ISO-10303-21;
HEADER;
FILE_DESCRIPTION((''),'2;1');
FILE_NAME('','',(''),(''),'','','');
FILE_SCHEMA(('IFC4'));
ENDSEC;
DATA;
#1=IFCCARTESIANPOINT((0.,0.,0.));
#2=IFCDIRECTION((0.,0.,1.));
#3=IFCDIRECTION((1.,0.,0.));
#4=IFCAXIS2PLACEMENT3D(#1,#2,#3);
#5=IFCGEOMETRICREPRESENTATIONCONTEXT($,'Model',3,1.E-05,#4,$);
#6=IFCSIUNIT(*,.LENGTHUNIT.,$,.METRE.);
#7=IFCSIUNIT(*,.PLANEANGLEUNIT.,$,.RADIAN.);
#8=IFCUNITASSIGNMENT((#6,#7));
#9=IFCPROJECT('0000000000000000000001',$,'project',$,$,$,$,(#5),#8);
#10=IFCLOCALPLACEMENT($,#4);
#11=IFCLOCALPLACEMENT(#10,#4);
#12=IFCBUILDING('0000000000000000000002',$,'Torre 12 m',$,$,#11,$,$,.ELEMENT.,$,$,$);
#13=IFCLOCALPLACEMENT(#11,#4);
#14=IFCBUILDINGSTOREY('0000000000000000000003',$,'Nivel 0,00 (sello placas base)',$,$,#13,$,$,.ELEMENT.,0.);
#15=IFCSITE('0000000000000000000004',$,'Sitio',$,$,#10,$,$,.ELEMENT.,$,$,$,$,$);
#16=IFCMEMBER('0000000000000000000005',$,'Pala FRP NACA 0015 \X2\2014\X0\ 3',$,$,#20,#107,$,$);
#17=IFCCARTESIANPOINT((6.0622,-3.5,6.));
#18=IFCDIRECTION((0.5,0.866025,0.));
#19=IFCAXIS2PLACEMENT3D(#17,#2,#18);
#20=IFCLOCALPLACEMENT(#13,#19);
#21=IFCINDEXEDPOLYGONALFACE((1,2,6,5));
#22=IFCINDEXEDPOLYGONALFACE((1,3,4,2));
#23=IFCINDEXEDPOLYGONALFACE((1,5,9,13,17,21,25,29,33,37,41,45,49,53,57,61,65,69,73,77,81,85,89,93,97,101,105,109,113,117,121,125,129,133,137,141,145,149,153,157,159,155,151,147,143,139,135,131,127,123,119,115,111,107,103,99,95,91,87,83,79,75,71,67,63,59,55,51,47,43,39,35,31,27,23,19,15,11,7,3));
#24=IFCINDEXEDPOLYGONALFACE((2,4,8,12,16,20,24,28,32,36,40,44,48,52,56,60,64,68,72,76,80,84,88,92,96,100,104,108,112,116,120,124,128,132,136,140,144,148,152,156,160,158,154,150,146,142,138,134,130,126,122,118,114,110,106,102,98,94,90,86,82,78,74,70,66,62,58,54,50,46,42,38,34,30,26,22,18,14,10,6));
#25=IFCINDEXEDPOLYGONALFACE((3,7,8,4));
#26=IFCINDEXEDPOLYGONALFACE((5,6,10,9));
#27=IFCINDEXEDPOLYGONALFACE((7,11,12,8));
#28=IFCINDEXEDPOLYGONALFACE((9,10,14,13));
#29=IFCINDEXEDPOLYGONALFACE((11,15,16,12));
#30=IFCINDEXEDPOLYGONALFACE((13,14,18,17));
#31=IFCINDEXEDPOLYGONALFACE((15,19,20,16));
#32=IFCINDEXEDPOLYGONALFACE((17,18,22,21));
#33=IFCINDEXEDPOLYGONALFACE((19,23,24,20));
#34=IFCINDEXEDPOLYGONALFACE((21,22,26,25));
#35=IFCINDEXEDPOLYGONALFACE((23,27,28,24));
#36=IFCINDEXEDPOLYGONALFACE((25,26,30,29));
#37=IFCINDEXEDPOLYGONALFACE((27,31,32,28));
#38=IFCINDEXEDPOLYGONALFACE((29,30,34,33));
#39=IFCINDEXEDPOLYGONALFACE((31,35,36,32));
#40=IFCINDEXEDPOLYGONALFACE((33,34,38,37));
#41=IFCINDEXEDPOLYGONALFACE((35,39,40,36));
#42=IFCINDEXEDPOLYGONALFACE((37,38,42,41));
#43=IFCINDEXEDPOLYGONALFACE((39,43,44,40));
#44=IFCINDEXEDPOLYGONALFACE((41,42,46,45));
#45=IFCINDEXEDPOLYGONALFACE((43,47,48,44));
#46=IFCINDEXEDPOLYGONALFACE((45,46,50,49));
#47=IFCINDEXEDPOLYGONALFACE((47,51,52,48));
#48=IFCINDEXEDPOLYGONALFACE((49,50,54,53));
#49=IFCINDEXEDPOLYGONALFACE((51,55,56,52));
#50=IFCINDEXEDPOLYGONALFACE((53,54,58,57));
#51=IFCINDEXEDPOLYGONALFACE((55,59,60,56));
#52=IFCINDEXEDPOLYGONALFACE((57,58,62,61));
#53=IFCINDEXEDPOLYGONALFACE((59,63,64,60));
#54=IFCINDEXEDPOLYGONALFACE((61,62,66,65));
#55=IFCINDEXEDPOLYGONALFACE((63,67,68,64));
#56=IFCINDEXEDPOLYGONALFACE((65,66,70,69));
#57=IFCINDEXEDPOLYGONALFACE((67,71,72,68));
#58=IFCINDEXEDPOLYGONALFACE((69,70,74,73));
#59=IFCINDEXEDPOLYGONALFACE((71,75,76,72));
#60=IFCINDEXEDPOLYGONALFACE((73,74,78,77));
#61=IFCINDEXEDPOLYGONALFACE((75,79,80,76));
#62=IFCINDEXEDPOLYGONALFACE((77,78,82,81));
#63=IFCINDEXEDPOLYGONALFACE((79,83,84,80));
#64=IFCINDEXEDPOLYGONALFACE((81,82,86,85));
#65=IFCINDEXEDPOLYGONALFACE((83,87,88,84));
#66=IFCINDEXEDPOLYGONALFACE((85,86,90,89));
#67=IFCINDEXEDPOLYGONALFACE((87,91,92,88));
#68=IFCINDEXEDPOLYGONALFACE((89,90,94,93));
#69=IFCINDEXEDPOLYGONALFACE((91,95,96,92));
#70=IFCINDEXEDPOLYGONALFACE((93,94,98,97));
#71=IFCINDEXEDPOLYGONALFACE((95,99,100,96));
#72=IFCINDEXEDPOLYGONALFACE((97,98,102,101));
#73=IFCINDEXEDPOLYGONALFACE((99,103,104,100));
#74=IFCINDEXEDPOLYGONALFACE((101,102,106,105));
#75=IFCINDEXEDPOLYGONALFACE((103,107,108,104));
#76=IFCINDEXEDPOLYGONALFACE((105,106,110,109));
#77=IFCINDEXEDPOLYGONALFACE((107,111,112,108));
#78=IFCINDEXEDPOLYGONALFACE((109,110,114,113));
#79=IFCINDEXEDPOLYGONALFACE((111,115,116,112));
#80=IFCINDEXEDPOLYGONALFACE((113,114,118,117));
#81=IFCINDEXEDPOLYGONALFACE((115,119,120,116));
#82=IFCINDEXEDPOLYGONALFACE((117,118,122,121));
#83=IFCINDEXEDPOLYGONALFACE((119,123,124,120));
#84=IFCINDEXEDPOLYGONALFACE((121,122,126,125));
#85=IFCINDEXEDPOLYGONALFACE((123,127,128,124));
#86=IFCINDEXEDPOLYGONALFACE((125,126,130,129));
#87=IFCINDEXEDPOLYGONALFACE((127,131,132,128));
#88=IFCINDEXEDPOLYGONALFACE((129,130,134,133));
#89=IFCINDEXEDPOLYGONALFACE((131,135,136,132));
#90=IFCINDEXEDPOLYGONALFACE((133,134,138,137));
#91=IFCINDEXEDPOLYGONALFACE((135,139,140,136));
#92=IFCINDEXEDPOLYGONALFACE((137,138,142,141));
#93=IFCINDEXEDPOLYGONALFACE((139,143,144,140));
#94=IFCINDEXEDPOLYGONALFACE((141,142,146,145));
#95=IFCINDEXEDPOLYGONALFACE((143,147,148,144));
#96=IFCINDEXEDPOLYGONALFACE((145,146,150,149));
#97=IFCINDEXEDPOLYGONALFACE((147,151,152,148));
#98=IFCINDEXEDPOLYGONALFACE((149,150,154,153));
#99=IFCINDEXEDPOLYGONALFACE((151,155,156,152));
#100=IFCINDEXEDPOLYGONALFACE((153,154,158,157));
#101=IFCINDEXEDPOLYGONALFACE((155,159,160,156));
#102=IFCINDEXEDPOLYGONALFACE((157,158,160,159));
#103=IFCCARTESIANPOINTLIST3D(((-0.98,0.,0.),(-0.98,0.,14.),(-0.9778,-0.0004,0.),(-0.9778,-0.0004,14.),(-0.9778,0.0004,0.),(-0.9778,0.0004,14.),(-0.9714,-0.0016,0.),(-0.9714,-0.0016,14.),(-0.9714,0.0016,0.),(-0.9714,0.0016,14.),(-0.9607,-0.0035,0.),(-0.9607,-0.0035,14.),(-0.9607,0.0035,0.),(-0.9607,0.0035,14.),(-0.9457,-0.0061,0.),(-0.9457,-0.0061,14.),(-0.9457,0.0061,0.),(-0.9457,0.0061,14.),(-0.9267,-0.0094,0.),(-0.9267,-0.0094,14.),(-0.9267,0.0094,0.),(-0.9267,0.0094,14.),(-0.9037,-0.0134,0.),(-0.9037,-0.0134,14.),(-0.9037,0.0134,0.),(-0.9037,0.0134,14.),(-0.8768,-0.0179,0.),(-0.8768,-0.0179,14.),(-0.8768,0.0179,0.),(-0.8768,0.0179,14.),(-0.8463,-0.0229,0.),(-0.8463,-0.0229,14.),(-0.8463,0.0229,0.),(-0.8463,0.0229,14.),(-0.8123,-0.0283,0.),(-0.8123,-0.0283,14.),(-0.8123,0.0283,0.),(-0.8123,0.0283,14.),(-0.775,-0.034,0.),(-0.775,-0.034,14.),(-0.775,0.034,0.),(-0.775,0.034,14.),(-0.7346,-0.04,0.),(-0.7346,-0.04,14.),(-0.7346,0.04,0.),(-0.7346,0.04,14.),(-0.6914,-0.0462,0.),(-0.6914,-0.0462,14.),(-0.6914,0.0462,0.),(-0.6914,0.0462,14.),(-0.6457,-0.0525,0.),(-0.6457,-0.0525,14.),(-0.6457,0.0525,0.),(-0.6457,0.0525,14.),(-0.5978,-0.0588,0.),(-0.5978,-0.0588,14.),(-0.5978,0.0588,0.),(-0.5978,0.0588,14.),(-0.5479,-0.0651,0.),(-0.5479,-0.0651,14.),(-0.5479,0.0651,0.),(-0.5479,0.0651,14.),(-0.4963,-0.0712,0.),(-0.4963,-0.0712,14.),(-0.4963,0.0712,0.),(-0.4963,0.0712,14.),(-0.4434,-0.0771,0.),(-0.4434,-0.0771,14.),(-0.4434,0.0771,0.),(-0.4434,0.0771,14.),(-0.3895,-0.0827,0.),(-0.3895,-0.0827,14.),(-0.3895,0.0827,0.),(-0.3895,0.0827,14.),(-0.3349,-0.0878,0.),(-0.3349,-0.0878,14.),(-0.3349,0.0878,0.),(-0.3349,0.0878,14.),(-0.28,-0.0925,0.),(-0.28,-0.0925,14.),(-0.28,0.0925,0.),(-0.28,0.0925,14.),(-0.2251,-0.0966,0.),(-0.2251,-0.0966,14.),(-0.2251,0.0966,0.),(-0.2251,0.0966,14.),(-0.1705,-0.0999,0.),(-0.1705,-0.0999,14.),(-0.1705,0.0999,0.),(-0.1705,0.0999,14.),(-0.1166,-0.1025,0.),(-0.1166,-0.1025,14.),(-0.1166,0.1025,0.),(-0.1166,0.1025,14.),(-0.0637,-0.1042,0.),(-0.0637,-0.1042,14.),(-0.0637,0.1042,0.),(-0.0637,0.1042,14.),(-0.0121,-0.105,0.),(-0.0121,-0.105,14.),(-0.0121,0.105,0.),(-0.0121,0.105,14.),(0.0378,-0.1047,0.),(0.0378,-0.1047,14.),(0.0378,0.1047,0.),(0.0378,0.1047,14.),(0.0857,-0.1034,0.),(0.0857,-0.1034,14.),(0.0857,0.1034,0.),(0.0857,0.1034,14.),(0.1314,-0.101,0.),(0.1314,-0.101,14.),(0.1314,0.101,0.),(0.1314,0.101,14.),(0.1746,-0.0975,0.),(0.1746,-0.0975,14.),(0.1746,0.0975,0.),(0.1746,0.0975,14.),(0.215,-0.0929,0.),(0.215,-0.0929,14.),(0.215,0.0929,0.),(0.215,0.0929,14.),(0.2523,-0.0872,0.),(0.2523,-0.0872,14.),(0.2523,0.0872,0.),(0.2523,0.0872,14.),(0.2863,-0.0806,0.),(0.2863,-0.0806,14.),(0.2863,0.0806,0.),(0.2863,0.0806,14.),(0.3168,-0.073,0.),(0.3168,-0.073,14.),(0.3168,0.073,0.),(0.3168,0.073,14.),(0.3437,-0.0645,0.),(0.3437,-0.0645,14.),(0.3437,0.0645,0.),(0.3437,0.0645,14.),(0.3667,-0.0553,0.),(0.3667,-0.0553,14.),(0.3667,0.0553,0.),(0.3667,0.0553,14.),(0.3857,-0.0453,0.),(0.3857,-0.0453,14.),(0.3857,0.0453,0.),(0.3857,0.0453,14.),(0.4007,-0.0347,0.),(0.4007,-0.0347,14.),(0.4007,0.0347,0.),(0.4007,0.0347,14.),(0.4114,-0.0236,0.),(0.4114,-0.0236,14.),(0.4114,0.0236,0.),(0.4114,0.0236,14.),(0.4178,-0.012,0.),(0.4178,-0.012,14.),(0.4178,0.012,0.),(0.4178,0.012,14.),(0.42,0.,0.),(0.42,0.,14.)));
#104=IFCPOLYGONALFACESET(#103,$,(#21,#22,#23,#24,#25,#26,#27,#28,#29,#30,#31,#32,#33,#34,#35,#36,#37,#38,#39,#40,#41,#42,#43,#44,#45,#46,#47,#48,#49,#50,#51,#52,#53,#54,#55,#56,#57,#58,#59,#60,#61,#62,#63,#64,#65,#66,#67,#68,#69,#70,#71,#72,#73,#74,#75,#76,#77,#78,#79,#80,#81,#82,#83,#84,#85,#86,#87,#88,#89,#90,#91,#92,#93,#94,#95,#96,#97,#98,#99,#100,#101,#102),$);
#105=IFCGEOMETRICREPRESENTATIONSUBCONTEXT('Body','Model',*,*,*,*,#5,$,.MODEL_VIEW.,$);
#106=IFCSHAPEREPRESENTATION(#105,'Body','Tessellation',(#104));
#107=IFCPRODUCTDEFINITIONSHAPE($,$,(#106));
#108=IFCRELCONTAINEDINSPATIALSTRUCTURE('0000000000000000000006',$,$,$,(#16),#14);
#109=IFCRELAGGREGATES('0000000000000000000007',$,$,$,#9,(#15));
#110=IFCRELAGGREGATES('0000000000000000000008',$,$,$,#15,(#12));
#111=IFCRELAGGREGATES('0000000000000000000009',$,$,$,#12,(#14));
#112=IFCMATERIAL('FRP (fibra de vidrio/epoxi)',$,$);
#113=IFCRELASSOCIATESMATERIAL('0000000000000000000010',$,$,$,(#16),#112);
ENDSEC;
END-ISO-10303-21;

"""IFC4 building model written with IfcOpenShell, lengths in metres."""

from ifc_helpers import new_model, si_unit, frame, origin, origin_with_axes, place, context, subcontext, project, spatial, polyline, outline, extrude, material, element, save


model = new_model("IFC4")

# Units and contexts
model_context = context("Model", 3, precision=1e-05, world=origin_with_axes())
body_context = subcontext(model_context, "Body", "Model", "MODEL_VIEW")
ifc_project = project(units=[si_unit("LENGTHUNIT", "METRE"), si_unit("PLANEANGLEUNIT", "RADIAN")], contexts=[model_context])

# Site, building, storey
site_placement = place(None, origin_with_axes())
site = spatial("IfcSite", under=ifc_project, at=site_placement, Name="Sitio", CompositionType="ELEMENT")
building_placement = place(site_placement, origin_with_axes())
building = spatial("IfcBuilding", under=site, at=building_placement, Name="Torre 12 m", CompositionType="ELEMENT")
storey_placement = place(building_placement, origin_with_axes())
storey = spatial("IfcBuildingStorey", under=building, at=storey_placement, Name="Nivel 0,00 (sello placas base)", CompositionType="ELEMENT", Elevation=0.0)

# Member
ifc_material_1 = material(Name="FRP (fibra de vidrio/epoxi)")
member_1_placement = place(storey_placement, frame((6.0622, -3.5, 6.0), z_axis=(0.0, 0.0, 1.0), x_axis=(0.5, 0.866025, 0.0)))
element("IfcMember", 1, at=member_1_placement, inside=storey, material=ifc_material_1, Name="Pala FRP NACA 0015 — 3", context=body_context, shape_type="SweptSolid", body=[
    extrude(outline(polyline([(0.42, 0.0), (0.4178, 0.012), (0.4114, 0.0236), (0.4007, 0.0347), (0.3857, 0.0453), (0.3667, 0.0553), (0.3437, 0.0645), (0.3168, 0.073), (0.2863, 0.0806), (0.2523, 0.0872), (0.215, 0.0929), (0.1746, 0.0975), (0.1314, 0.101), (0.0857, 0.1034), (0.0378, 0.1047), (-0.0121, 0.105), (-0.0637, 0.1042), (-0.1166, 0.1025), (-0.1705, 0.0999), (-0.2251, 0.0966), (-0.28, 0.0925), (-0.3349, 0.0878), (-0.3895, 0.0827), (-0.4434, 0.0771), (-0.4963, 0.0712), (-0.5479, 0.0651), (-0.5978, 0.0588), (-0.6457, 0.0525), (-0.6914, 0.0462), (-0.7346, 0.04), (-0.775, 0.034), (-0.8123, 0.0283), (-0.8463, 0.0229), (-0.8768, 0.0179), (-0.9037, 0.0134), (-0.9267, 0.0094), (-0.9457, 0.0061), (-0.9607, 0.0035), (-0.9714, 0.0016), (-0.9778, 0.0004), (-0.98, 0.0), (-0.9778, -0.0004), (-0.9714, -0.0016), (-0.9607, -0.0035), (-0.9457, -0.0061), (-0.9267, -0.0094), (-0.9037, -0.0134), (-0.8768, -0.0179), (-0.8463, -0.0229), (-0.8123, -0.0283), (-0.775, -0.034), (-0.7346, -0.04), (-0.6914, -0.0462), (-0.6457, -0.0525), (-0.5978, -0.0588), (-0.5479, -0.0651), (-0.4963, -0.0712), (-0.4434, -0.0771), (-0.3895, -0.0827), (-0.3349, -0.0878), (-0.28, -0.0925), (-0.2251, -0.0966), (-0.1705, -0.0999), (-0.1166, -0.1025), (-0.0637, -0.1042), (-0.0121, -0.105), (0.0378, -0.1047), (0.0857, -0.1034), (0.1314, -0.101), (0.1746, -0.0975), (0.215, -0.0929), (0.2523, -0.0872), (0.2863, -0.0806), (0.3168, -0.073), (0.3437, -0.0645), (0.3667, -0.0553), (0.3857, -0.0453), (0.4007, -0.0347), (0.4114, -0.0236), (0.4178, -0.012), (0.42, 0.0)])), origin(), (0.0, 0.0, 1.0), 14.0),
])

save(model, "model.ifc")
